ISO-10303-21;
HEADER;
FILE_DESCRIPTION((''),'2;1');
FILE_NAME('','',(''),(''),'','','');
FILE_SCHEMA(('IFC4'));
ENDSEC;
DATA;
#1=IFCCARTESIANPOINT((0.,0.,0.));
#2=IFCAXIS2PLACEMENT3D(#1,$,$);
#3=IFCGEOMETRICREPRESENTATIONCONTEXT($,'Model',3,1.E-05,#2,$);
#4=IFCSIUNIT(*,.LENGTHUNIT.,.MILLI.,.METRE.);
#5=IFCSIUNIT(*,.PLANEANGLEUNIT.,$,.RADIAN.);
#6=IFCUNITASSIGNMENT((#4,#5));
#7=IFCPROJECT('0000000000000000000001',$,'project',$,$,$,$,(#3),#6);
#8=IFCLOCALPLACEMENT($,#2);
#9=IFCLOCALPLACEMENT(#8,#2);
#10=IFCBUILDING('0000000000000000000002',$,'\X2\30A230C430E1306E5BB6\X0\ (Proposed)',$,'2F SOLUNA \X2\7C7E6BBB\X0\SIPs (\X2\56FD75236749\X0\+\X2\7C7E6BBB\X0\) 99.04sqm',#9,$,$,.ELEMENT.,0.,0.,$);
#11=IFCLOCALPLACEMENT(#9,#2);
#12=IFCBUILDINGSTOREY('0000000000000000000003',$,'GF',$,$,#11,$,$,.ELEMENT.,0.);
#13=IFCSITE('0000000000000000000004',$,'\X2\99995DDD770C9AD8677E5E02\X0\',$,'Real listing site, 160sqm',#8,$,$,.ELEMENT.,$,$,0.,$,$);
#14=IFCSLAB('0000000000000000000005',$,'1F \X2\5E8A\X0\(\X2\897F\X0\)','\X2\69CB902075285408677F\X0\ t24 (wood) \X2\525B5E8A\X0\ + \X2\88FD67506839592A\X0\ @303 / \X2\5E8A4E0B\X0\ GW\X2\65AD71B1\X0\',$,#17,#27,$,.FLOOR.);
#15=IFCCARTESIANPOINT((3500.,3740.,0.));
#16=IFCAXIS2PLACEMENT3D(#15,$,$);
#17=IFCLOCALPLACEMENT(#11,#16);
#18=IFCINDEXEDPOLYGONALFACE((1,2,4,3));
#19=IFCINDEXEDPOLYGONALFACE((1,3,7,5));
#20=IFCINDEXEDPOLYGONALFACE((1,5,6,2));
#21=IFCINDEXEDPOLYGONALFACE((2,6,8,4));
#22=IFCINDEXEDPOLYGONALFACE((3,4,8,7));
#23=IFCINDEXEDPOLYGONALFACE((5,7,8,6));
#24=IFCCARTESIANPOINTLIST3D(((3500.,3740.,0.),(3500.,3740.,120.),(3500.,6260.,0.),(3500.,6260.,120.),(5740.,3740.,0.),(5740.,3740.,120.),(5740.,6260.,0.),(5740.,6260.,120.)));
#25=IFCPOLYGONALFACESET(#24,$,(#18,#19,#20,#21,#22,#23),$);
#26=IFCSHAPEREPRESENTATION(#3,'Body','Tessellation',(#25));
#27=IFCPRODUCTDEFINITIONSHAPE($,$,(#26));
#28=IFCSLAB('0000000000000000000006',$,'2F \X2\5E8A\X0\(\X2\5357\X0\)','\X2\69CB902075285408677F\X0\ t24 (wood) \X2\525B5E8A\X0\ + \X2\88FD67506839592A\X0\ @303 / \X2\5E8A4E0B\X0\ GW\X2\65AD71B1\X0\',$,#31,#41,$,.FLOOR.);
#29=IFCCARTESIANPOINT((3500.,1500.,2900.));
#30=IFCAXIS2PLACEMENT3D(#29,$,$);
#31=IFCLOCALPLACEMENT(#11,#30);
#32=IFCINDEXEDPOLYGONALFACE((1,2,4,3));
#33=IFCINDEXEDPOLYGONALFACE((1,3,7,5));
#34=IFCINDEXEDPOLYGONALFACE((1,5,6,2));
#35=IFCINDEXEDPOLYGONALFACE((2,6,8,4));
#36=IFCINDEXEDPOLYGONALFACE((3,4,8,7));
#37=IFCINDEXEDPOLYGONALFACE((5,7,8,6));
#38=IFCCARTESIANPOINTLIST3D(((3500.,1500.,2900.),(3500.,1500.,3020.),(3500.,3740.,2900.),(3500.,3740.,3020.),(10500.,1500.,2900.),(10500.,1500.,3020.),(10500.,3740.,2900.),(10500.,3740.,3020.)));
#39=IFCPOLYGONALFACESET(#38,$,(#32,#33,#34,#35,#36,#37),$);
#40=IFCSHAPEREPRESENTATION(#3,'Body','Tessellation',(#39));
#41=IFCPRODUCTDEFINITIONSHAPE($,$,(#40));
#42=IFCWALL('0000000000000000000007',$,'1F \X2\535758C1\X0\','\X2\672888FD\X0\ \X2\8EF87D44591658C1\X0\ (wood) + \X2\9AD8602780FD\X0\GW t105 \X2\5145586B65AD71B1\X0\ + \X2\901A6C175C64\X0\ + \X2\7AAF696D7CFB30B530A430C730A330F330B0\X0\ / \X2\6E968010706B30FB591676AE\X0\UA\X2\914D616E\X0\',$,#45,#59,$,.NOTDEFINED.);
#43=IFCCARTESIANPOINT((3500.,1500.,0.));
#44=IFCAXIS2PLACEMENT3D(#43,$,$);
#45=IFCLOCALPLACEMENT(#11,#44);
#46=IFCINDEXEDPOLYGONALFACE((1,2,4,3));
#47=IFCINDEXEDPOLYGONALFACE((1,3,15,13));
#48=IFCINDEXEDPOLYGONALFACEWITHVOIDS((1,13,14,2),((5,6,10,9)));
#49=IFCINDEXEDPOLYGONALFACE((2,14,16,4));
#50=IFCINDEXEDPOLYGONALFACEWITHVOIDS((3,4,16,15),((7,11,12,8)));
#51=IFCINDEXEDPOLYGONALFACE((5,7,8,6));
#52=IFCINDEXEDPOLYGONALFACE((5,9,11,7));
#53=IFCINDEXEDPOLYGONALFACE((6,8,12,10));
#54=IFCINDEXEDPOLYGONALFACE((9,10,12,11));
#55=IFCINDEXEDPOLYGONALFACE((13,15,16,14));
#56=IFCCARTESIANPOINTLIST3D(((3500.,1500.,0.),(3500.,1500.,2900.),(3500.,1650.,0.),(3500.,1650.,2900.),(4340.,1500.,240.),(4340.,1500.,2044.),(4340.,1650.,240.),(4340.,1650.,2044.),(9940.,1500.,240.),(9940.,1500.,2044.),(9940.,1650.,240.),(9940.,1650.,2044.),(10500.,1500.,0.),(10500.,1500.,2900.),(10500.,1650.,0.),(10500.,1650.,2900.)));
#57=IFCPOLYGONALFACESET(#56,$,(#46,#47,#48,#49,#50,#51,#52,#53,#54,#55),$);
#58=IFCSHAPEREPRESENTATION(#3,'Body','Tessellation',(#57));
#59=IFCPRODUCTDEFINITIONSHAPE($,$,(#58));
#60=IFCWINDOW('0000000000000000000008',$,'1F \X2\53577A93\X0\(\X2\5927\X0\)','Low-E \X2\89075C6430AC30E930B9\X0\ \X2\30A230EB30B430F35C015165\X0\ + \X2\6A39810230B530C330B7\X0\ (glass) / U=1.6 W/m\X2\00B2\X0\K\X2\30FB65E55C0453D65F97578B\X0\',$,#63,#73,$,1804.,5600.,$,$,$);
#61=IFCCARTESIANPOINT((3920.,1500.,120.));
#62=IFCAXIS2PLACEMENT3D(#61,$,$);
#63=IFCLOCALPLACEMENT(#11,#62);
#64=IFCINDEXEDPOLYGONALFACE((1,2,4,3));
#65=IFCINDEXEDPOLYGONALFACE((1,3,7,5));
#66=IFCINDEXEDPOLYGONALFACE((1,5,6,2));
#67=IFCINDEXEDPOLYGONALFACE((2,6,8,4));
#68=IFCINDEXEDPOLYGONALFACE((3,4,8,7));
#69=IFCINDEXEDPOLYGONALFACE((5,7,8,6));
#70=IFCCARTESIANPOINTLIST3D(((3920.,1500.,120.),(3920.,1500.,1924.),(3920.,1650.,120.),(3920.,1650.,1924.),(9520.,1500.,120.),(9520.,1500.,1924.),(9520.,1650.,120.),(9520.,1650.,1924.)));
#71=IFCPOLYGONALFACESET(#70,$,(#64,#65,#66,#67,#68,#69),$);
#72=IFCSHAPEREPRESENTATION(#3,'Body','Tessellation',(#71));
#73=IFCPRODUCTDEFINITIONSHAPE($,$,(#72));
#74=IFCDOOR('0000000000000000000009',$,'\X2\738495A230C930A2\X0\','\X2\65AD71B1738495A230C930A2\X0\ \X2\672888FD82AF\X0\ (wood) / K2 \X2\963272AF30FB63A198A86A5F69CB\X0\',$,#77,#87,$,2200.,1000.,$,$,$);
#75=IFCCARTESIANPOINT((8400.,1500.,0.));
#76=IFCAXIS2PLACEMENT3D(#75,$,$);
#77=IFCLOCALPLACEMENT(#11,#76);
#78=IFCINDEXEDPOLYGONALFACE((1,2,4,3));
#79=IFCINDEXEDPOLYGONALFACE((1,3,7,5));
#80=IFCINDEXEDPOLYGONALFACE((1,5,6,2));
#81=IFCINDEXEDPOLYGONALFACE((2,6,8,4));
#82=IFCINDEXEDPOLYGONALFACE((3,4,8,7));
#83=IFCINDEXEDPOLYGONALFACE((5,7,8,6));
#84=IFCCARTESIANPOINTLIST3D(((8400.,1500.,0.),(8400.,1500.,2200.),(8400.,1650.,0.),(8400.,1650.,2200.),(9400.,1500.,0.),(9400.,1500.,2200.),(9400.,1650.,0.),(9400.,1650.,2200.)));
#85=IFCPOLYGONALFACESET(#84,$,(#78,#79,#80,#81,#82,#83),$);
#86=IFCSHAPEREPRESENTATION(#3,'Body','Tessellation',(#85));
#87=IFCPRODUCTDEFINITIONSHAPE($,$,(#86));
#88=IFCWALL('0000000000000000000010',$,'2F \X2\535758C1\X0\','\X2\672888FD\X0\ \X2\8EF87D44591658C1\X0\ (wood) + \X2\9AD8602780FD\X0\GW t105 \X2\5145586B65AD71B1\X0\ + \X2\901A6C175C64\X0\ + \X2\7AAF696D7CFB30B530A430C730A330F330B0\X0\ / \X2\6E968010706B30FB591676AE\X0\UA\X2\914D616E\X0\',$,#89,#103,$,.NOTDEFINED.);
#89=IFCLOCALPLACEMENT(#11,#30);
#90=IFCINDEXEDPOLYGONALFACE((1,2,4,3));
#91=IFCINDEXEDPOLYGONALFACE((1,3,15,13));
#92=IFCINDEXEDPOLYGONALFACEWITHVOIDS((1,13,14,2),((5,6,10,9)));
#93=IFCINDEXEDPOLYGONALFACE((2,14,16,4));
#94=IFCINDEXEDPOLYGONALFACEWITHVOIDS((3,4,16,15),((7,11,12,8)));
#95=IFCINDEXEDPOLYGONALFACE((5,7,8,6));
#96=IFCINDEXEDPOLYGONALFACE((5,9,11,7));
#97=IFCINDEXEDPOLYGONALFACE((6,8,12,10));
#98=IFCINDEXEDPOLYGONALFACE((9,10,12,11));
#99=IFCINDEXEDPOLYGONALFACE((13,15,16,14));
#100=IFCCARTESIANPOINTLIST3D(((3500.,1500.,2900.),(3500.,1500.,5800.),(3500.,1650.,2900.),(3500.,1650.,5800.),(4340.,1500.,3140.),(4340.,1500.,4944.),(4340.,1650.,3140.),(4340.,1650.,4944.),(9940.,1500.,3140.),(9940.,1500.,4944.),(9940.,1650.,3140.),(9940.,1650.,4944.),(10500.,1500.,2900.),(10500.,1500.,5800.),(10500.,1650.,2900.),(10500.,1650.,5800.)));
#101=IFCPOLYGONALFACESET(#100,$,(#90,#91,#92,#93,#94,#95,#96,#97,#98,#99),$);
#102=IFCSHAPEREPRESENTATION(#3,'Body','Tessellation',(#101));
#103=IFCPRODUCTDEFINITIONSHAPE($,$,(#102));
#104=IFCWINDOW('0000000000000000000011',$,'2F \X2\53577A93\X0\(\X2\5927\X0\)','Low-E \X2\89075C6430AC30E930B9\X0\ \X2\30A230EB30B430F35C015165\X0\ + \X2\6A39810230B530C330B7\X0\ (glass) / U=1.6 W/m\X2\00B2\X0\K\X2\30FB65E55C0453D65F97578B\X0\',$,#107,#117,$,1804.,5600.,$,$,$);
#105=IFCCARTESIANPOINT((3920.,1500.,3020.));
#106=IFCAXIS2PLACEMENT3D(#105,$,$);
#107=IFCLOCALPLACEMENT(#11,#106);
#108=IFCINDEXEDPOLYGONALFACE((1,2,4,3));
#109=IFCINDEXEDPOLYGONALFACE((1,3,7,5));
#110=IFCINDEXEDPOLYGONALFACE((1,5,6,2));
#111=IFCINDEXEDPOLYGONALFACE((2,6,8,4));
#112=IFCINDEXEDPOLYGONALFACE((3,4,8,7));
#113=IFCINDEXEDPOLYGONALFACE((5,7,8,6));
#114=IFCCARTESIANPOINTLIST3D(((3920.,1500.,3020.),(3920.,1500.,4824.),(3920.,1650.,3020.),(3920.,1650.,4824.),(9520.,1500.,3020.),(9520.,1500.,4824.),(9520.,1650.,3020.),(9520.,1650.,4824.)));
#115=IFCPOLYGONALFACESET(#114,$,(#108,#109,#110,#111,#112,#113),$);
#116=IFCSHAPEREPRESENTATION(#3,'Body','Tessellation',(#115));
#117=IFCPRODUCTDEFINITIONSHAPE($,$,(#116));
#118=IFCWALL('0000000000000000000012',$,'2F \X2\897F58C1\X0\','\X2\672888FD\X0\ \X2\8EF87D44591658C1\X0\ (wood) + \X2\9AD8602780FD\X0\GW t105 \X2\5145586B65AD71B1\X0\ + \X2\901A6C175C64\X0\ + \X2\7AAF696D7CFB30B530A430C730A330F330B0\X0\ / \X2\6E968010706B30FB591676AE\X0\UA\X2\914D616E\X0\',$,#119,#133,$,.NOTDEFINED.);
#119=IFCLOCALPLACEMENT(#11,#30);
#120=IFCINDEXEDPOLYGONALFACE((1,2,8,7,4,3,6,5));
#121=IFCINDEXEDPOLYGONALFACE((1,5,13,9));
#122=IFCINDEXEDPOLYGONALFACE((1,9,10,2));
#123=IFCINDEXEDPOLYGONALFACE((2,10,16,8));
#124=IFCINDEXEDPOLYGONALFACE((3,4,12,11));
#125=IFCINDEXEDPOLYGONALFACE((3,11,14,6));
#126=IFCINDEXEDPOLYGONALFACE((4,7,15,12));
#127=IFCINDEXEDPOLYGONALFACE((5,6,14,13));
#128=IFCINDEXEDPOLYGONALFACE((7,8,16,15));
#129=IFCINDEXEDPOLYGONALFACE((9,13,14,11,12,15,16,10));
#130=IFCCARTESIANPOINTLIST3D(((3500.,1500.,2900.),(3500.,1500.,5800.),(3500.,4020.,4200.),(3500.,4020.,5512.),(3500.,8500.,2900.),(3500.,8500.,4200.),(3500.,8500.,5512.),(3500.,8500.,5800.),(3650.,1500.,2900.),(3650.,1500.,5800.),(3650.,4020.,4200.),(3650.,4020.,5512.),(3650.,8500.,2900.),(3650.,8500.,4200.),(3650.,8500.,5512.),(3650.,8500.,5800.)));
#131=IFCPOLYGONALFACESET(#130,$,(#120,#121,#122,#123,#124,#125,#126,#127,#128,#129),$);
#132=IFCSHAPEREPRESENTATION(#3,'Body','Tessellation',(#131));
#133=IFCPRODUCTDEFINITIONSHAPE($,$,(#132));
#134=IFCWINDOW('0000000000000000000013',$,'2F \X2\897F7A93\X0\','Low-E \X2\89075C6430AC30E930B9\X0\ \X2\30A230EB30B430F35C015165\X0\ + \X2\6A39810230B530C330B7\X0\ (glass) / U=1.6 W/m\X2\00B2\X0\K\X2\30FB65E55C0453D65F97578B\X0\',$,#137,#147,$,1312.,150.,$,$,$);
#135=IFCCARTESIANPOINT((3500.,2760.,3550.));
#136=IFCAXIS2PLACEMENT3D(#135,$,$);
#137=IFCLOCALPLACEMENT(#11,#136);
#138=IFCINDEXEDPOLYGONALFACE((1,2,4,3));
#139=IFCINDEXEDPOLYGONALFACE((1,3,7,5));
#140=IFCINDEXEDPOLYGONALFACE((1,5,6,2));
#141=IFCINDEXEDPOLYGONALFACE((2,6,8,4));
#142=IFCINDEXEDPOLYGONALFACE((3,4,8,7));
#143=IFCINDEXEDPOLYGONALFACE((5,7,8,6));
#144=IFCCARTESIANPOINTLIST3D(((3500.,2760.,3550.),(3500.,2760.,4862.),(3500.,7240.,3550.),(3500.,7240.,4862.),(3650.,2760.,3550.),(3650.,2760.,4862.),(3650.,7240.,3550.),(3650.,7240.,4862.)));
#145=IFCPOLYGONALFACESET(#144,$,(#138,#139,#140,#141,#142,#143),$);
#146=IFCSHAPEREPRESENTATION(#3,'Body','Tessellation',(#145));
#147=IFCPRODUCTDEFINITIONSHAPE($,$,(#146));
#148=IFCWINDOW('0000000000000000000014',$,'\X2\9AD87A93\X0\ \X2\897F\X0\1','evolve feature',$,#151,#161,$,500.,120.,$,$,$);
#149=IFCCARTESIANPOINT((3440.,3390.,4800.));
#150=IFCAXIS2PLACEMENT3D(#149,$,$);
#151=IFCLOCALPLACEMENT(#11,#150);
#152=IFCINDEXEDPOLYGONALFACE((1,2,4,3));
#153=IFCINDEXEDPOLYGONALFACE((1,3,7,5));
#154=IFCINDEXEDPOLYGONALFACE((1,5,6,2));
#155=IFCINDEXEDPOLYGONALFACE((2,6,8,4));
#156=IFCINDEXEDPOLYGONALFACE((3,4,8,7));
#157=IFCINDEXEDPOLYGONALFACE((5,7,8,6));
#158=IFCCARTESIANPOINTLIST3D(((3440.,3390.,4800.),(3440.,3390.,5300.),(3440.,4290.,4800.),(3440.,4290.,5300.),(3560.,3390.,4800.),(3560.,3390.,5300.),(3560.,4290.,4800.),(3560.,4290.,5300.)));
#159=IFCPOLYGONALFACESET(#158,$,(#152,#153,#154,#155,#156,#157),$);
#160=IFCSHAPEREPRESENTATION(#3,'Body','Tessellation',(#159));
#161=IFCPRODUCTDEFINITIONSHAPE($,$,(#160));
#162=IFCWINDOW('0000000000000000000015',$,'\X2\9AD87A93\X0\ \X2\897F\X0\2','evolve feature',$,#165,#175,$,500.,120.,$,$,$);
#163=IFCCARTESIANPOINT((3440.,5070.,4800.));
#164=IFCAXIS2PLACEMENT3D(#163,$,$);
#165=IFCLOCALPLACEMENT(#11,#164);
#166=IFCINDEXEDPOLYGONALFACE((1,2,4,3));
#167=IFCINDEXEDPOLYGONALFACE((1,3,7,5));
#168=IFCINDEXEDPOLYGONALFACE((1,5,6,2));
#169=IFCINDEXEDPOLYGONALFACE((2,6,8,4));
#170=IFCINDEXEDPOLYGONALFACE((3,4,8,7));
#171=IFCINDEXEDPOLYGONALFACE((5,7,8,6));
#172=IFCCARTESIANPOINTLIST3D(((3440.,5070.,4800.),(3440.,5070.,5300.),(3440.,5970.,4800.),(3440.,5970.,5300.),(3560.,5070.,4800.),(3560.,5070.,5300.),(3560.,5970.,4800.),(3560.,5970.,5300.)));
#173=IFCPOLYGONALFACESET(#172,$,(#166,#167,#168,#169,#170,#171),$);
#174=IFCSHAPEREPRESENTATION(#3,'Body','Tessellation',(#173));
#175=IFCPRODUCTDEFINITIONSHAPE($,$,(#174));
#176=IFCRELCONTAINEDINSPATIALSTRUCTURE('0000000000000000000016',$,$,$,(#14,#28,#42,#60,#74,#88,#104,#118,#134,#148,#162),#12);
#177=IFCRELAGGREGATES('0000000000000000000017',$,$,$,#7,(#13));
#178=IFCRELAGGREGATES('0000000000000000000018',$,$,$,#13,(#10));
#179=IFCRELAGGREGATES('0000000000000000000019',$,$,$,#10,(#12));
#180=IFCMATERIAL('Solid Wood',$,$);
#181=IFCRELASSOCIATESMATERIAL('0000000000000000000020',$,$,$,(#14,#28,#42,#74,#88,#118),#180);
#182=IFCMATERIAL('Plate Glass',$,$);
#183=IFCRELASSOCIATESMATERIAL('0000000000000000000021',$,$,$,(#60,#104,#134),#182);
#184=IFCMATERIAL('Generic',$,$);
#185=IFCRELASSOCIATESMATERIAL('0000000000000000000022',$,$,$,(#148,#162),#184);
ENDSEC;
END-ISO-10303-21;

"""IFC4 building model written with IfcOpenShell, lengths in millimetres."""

from ifc_helpers import new_model, si_unit, frame, frame_2d, origin, place, context, project, spatial, rectangle, extrude, material, element, fill, save


model = new_model("IFC4")

# Units and contexts
model_context = context("Model", 3, precision=1e-05, world=origin())
ifc_project = project(units=[si_unit("LENGTHUNIT", "METRE", prefix="MILLI"), si_unit("PLANEANGLEUNIT", "RADIAN")], contexts=[model_context])

# Site, building, storey
site_placement = place(None, origin())
site = spatial("IfcSite", under=ifc_project, at=site_placement, Name="香川県高松市", ObjectType="Real listing site, 160sqm", CompositionType="ELEMENT", RefElevation=0.0)
building_placement = place(site_placement, origin())
building = spatial("IfcBuilding", under=site, at=building_placement, Name="アツメの家 (Proposed)", ObjectType="2F SOLUNA 籾殻SIPs (国産杉+籾殻) 99.04sqm", CompositionType="ELEMENT", ElevationOfRefHeight=0.0, ElevationOfTerrain=0.0)
storey_placement = place(building_placement, origin())
storey = spatial("IfcBuildingStorey", under=building, at=storey_placement, Name="GF", CompositionType="ELEMENT", Elevation=0.0)

# Slabs
ifc_material_1 = material(Name="Solid Wood")
slab_1_placement = place(storey_placement, frame((3500.0, 3740.0, 0.0)))
element("IfcSlab", 1, at=slab_1_placement, inside=storey, material=ifc_material_1, Name="1F 床(西)", Description="構造用合板 t24 (wood) 剛床 + 製材根太 @303 / 床下 GW断熱", PredefinedType="FLOOR", context=model_context, shape_type="SweptSolid", body=[
    extrude(rectangle(XDim=2240.0, YDim=2520.0, at=frame_2d((1120.0, 1260.0))), frame((3500.0, 3740.0, 0.0)), (0.0, 0.0, 1.0), 120.0),
])
slab_2_placement = place(storey_placement, frame((3500.0, 1500.0, 2900.0)))
element("IfcSlab", 2, at=slab_2_placement, inside=storey, material=ifc_material_1, Name="2F 床(南)", Description="構造用合板 t24 (wood) 剛床 + 製材根太 @303 / 床下 GW断熱", PredefinedType="FLOOR", context=model_context, shape_type="SweptSolid", body=[
    extrude(rectangle(XDim=7000.0, YDim=2240.0, at=frame_2d((3500.0, 1120.0))), frame((3500.0, 1500.0, 2900.0)), (0.0, 0.0, 1.0), 120.0),
])
ifc_material_2 = material(Name="Generic")

# Wall, openings, window, door
wall_1_placement = place(storey_placement, frame((3500.0, 1500.0, 0.0)))
wall_1 = element("IfcWall", 3, at=wall_1_placement, inside=storey, material=ifc_material_1, Name="1F 南壁", Description="木製 軸組外壁 (wood) + 高性能GW t105 充填断熱 + 通気層 + 窯業系サイディング / 準耐火・外皮UA配慮", PredefinedType="NOTDEFINED", context=model_context, shape_type="SweptSolid", body=[
    extrude(rectangle(XDim=7000.0, YDim=150.0, at=frame_2d((3500.0, 75.0))), frame((3500.0, 1500.0, 0.0)), (0.0, 0.0, 1.0), 2900.0),
])
opening_1_placement = place(storey_placement, frame((3920.0, 1500.0, 120.0)))
opening_1 = element("IfcOpeningElement", 4, at=opening_1_placement, cuts=wall_1, PredefinedType="NOTDEFINED", context=model_context, shape_type="SweptSolid", body=[
    extrude(rectangle(XDim=5600.0, YDim=150.0, at=frame_2d((2800.0, 75.0))), frame((3920.0, 1500.0, 120.0)), (0.0, 0.0, 1.0), 1804.0),
])
opening_2_placement = place(storey_placement, frame((8400.0, 1500.0, 0.0)))
opening_2 = element("IfcOpeningElement", 5, at=opening_2_placement, cuts=wall_1, PredefinedType="NOTDEFINED", context=model_context, shape_type="SweptSolid", body=[
    extrude(rectangle(XDim=1000.0, YDim=150.0, at=frame_2d((500.0, 75.0))), frame((8400.0, 1500.0, 0.0)), (0.0, 0.0, 1.0), 2200.0),
])
ifc_material_3 = material(Name="Plate Glass")
window_1_placement = place(storey_placement, frame((3920.0, 1500.0, 120.0)))
window_1 = element("IfcWindow", 6, at=window_1_placement, inside=storey, material=ifc_material_3, Name="1F 南窓(大)", Description="Low-E 複層ガラス アルゴン封入 + 樹脂サッシ (glass) / U=1.6 W/m²K・日射取得型", OverallHeight=1804.0, OverallWidth=5600.0, context=model_context, shape_type="SweptSolid", body=[
    extrude(rectangle(XDim=5600.0, YDim=150.0, at=frame_2d((2800.0, 75.0))), frame((3920.0, 1500.0, 120.0)), (0.0, 0.0, 1.0), 1804.0),
])
fill(opening_1, window_1)
door_placement = place(storey_placement, frame((8400.0, 1500.0, 0.0)))
door = element("IfcDoor", 7, at=door_placement, inside=storey, material=ifc_material_1, Name="玄関ドア", Description="断熱玄関ドア 木製芯 (wood) / K2 防犯・採風機構", OverallHeight=2200.0, OverallWidth=1000.0, context=model_context, shape_type="SweptSolid", body=[
    extrude(rectangle(XDim=1000.0, YDim=150.0, at=frame_2d((500.0, 75.0))), frame((8400.0, 1500.0, 0.0)), (0.0, 0.0, 1.0), 2200.0),
])
fill(opening_2, door)

# Wall, opening, window
wall_2_placement = place(storey_placement, frame((3500.0, 1500.0, 2900.0)))
wall_2 = element("IfcWall", 8, at=wall_2_placement, inside=storey, material=ifc_material_1, Name="2F 南壁", Description="木製 軸組外壁 (wood) + 高性能GW t105 充填断熱 + 通気層 + 窯業系サイディング / 準耐火・外皮UA配慮", PredefinedType="NOTDEFINED", context=model_context, shape_type="SweptSolid", body=[
    extrude(rectangle(XDim=7000.0, YDim=150.0, at=frame_2d((3500.0, 75.0))), frame((3500.0, 1500.0, 2900.0)), (0.0, 0.0, 1.0), 2900.0),
])
opening_3_placement = place(storey_placement, frame((3920.0, 1500.0, 3020.0)))
opening_3 = element("IfcOpeningElement", 9, at=opening_3_placement, cuts=wall_2, PredefinedType="NOTDEFINED", context=model_context, shape_type="SweptSolid", body=[
    extrude(rectangle(XDim=5600.0, YDim=150.0, at=frame_2d((2800.0, 75.0))), frame((3920.0, 1500.0, 3020.0)), (0.0, 0.0, 1.0), 1804.0),
])
window_2_placement = place(storey_placement, frame((3920.0, 1500.0, 3020.0)))
window_2 = element("IfcWindow", 10, at=window_2_placement, inside=storey, material=ifc_material_3, Name="2F 南窓(大)", Description="Low-E 複層ガラス アルゴン封入 + 樹脂サッシ (glass) / U=1.6 W/m²K・日射取得型", OverallHeight=1804.0, OverallWidth=5600.0, context=model_context, shape_type="SweptSolid", body=[
    extrude(rectangle(XDim=5600.0, YDim=150.0, at=frame_2d((2800.0, 75.0))), frame((3920.0, 1500.0, 3020.0)), (0.0, 0.0, 1.0), 1804.0),
])
fill(opening_3, window_2)

# Wall, openings, windows
wall_3_placement = place(storey_placement, frame((3500.0, 1500.0, 2900.0)))
wall_3 = element("IfcWall", 11, at=wall_3_placement, inside=storey, material=ifc_material_1, Name="2F 西壁", Description="木製 軸組外壁 (wood) + 高性能GW t105 充填断熱 + 通気層 + 窯業系サイディング / 準耐火・外皮UA配慮", PredefinedType="NOTDEFINED", context=model_context, shape_type="SweptSolid", body=[
    extrude(rectangle(XDim=150.0, YDim=7000.0, at=frame_2d((75.0, 3500.0))), frame((3500.0, 1500.0, 2900.0)), (0.0, 0.0, 1.0), 2900.0),
])
opening_4_placement = place(storey_placement, frame((3500.0, 2760.0, 3550.0)))
opening_4 = element("IfcOpeningElement", 12, at=opening_4_placement, cuts=wall_3, PredefinedType="NOTDEFINED", context=model_context, shape_type="SweptSolid", body=[
    extrude(rectangle(XDim=150.0, YDim=4480.0, at=frame_2d((75.0, 2240.0))), frame((3500.0, 2760.0, 3550.0)), (0.0, 0.0, 1.0), 1312.0),
])
opening_5_placement = place(storey_placement, frame((3440.0, 3390.0, 4800.0)))
opening_5 = element("IfcOpeningElement", 13, at=opening_5_placement, cuts=wall_3, PredefinedType="NOTDEFINED", context=model_context, shape_type="SweptSolid", body=[
    extrude(rectangle(XDim=120.0, YDim=900.0, at=frame_2d((60.0, 450.0))), frame((3440.0, 3390.0, 4800.0)), (0.0, 0.0, 1.0), 500.0),
])
opening_6_placement = place(storey_placement, frame((3440.0, 5070.0, 4800.0)))
opening_6 = element("IfcOpeningElement", 14, at=opening_6_placement, cuts=wall_3, PredefinedType="NOTDEFINED", context=model_context, shape_type="SweptSolid", body=[
    extrude(rectangle(XDim=120.0, YDim=900.0, at=frame_2d((60.0, 450.0))), frame((3440.0, 5070.0, 4800.0)), (0.0, 0.0, 1.0), 500.0),
])
window_3_placement = place(storey_placement, frame((3500.0, 2760.0, 3550.0)))
window_3 = element("IfcWindow", 15, at=window_3_placement, inside=storey, material=ifc_material_3, Name="2F 西窓", Description="Low-E 複層ガラス アルゴン封入 + 樹脂サッシ (glass) / U=1.6 W/m²K・日射取得型", OverallHeight=1312.0, OverallWidth=150.0, context=model_context, shape_type="SweptSolid", body=[
    extrude(rectangle(XDim=150.0, YDim=4480.0, at=frame_2d((75.0, 2240.0))), frame((3500.0, 2760.0, 3550.0)), (0.0, 0.0, 1.0), 1312.0),
])
fill(opening_4, window_3)
window_4_placement = place(storey_placement, frame((3440.0, 3390.0, 4800.0)))
window_4 = element("IfcWindow", 16, at=window_4_placement, inside=storey, material=ifc_material_2, Name="高窓 西1", Description="evolve feature", OverallHeight=500.0, OverallWidth=120.0, context=model_context, shape_type="SweptSolid", body=[
    extrude(rectangle(XDim=120.0, YDim=900.0, at=frame_2d((60.0, 450.0))), frame((3440.0, 3390.0, 4800.0)), (0.0, 0.0, 1.0), 500.0),
])
fill(opening_5, window_4)
window_5_placement = place(storey_placement, frame((3440.0, 5070.0, 4800.0)))
window_5 = element("IfcWindow", 17, at=window_5_placement, inside=storey, material=ifc_material_2, Name="高窓 西2", Description="evolve feature", OverallHeight=500.0, OverallWidth=120.0, context=model_context, shape_type="SweptSolid", body=[
    extrude(rectangle(XDim=120.0, YDim=900.0, at=frame_2d((60.0, 450.0))), frame((3440.0, 5070.0, 4800.0)), (0.0, 0.0, 1.0), 500.0),
])
fill(opening_6, window_5)

save(model, "model.ifc")
